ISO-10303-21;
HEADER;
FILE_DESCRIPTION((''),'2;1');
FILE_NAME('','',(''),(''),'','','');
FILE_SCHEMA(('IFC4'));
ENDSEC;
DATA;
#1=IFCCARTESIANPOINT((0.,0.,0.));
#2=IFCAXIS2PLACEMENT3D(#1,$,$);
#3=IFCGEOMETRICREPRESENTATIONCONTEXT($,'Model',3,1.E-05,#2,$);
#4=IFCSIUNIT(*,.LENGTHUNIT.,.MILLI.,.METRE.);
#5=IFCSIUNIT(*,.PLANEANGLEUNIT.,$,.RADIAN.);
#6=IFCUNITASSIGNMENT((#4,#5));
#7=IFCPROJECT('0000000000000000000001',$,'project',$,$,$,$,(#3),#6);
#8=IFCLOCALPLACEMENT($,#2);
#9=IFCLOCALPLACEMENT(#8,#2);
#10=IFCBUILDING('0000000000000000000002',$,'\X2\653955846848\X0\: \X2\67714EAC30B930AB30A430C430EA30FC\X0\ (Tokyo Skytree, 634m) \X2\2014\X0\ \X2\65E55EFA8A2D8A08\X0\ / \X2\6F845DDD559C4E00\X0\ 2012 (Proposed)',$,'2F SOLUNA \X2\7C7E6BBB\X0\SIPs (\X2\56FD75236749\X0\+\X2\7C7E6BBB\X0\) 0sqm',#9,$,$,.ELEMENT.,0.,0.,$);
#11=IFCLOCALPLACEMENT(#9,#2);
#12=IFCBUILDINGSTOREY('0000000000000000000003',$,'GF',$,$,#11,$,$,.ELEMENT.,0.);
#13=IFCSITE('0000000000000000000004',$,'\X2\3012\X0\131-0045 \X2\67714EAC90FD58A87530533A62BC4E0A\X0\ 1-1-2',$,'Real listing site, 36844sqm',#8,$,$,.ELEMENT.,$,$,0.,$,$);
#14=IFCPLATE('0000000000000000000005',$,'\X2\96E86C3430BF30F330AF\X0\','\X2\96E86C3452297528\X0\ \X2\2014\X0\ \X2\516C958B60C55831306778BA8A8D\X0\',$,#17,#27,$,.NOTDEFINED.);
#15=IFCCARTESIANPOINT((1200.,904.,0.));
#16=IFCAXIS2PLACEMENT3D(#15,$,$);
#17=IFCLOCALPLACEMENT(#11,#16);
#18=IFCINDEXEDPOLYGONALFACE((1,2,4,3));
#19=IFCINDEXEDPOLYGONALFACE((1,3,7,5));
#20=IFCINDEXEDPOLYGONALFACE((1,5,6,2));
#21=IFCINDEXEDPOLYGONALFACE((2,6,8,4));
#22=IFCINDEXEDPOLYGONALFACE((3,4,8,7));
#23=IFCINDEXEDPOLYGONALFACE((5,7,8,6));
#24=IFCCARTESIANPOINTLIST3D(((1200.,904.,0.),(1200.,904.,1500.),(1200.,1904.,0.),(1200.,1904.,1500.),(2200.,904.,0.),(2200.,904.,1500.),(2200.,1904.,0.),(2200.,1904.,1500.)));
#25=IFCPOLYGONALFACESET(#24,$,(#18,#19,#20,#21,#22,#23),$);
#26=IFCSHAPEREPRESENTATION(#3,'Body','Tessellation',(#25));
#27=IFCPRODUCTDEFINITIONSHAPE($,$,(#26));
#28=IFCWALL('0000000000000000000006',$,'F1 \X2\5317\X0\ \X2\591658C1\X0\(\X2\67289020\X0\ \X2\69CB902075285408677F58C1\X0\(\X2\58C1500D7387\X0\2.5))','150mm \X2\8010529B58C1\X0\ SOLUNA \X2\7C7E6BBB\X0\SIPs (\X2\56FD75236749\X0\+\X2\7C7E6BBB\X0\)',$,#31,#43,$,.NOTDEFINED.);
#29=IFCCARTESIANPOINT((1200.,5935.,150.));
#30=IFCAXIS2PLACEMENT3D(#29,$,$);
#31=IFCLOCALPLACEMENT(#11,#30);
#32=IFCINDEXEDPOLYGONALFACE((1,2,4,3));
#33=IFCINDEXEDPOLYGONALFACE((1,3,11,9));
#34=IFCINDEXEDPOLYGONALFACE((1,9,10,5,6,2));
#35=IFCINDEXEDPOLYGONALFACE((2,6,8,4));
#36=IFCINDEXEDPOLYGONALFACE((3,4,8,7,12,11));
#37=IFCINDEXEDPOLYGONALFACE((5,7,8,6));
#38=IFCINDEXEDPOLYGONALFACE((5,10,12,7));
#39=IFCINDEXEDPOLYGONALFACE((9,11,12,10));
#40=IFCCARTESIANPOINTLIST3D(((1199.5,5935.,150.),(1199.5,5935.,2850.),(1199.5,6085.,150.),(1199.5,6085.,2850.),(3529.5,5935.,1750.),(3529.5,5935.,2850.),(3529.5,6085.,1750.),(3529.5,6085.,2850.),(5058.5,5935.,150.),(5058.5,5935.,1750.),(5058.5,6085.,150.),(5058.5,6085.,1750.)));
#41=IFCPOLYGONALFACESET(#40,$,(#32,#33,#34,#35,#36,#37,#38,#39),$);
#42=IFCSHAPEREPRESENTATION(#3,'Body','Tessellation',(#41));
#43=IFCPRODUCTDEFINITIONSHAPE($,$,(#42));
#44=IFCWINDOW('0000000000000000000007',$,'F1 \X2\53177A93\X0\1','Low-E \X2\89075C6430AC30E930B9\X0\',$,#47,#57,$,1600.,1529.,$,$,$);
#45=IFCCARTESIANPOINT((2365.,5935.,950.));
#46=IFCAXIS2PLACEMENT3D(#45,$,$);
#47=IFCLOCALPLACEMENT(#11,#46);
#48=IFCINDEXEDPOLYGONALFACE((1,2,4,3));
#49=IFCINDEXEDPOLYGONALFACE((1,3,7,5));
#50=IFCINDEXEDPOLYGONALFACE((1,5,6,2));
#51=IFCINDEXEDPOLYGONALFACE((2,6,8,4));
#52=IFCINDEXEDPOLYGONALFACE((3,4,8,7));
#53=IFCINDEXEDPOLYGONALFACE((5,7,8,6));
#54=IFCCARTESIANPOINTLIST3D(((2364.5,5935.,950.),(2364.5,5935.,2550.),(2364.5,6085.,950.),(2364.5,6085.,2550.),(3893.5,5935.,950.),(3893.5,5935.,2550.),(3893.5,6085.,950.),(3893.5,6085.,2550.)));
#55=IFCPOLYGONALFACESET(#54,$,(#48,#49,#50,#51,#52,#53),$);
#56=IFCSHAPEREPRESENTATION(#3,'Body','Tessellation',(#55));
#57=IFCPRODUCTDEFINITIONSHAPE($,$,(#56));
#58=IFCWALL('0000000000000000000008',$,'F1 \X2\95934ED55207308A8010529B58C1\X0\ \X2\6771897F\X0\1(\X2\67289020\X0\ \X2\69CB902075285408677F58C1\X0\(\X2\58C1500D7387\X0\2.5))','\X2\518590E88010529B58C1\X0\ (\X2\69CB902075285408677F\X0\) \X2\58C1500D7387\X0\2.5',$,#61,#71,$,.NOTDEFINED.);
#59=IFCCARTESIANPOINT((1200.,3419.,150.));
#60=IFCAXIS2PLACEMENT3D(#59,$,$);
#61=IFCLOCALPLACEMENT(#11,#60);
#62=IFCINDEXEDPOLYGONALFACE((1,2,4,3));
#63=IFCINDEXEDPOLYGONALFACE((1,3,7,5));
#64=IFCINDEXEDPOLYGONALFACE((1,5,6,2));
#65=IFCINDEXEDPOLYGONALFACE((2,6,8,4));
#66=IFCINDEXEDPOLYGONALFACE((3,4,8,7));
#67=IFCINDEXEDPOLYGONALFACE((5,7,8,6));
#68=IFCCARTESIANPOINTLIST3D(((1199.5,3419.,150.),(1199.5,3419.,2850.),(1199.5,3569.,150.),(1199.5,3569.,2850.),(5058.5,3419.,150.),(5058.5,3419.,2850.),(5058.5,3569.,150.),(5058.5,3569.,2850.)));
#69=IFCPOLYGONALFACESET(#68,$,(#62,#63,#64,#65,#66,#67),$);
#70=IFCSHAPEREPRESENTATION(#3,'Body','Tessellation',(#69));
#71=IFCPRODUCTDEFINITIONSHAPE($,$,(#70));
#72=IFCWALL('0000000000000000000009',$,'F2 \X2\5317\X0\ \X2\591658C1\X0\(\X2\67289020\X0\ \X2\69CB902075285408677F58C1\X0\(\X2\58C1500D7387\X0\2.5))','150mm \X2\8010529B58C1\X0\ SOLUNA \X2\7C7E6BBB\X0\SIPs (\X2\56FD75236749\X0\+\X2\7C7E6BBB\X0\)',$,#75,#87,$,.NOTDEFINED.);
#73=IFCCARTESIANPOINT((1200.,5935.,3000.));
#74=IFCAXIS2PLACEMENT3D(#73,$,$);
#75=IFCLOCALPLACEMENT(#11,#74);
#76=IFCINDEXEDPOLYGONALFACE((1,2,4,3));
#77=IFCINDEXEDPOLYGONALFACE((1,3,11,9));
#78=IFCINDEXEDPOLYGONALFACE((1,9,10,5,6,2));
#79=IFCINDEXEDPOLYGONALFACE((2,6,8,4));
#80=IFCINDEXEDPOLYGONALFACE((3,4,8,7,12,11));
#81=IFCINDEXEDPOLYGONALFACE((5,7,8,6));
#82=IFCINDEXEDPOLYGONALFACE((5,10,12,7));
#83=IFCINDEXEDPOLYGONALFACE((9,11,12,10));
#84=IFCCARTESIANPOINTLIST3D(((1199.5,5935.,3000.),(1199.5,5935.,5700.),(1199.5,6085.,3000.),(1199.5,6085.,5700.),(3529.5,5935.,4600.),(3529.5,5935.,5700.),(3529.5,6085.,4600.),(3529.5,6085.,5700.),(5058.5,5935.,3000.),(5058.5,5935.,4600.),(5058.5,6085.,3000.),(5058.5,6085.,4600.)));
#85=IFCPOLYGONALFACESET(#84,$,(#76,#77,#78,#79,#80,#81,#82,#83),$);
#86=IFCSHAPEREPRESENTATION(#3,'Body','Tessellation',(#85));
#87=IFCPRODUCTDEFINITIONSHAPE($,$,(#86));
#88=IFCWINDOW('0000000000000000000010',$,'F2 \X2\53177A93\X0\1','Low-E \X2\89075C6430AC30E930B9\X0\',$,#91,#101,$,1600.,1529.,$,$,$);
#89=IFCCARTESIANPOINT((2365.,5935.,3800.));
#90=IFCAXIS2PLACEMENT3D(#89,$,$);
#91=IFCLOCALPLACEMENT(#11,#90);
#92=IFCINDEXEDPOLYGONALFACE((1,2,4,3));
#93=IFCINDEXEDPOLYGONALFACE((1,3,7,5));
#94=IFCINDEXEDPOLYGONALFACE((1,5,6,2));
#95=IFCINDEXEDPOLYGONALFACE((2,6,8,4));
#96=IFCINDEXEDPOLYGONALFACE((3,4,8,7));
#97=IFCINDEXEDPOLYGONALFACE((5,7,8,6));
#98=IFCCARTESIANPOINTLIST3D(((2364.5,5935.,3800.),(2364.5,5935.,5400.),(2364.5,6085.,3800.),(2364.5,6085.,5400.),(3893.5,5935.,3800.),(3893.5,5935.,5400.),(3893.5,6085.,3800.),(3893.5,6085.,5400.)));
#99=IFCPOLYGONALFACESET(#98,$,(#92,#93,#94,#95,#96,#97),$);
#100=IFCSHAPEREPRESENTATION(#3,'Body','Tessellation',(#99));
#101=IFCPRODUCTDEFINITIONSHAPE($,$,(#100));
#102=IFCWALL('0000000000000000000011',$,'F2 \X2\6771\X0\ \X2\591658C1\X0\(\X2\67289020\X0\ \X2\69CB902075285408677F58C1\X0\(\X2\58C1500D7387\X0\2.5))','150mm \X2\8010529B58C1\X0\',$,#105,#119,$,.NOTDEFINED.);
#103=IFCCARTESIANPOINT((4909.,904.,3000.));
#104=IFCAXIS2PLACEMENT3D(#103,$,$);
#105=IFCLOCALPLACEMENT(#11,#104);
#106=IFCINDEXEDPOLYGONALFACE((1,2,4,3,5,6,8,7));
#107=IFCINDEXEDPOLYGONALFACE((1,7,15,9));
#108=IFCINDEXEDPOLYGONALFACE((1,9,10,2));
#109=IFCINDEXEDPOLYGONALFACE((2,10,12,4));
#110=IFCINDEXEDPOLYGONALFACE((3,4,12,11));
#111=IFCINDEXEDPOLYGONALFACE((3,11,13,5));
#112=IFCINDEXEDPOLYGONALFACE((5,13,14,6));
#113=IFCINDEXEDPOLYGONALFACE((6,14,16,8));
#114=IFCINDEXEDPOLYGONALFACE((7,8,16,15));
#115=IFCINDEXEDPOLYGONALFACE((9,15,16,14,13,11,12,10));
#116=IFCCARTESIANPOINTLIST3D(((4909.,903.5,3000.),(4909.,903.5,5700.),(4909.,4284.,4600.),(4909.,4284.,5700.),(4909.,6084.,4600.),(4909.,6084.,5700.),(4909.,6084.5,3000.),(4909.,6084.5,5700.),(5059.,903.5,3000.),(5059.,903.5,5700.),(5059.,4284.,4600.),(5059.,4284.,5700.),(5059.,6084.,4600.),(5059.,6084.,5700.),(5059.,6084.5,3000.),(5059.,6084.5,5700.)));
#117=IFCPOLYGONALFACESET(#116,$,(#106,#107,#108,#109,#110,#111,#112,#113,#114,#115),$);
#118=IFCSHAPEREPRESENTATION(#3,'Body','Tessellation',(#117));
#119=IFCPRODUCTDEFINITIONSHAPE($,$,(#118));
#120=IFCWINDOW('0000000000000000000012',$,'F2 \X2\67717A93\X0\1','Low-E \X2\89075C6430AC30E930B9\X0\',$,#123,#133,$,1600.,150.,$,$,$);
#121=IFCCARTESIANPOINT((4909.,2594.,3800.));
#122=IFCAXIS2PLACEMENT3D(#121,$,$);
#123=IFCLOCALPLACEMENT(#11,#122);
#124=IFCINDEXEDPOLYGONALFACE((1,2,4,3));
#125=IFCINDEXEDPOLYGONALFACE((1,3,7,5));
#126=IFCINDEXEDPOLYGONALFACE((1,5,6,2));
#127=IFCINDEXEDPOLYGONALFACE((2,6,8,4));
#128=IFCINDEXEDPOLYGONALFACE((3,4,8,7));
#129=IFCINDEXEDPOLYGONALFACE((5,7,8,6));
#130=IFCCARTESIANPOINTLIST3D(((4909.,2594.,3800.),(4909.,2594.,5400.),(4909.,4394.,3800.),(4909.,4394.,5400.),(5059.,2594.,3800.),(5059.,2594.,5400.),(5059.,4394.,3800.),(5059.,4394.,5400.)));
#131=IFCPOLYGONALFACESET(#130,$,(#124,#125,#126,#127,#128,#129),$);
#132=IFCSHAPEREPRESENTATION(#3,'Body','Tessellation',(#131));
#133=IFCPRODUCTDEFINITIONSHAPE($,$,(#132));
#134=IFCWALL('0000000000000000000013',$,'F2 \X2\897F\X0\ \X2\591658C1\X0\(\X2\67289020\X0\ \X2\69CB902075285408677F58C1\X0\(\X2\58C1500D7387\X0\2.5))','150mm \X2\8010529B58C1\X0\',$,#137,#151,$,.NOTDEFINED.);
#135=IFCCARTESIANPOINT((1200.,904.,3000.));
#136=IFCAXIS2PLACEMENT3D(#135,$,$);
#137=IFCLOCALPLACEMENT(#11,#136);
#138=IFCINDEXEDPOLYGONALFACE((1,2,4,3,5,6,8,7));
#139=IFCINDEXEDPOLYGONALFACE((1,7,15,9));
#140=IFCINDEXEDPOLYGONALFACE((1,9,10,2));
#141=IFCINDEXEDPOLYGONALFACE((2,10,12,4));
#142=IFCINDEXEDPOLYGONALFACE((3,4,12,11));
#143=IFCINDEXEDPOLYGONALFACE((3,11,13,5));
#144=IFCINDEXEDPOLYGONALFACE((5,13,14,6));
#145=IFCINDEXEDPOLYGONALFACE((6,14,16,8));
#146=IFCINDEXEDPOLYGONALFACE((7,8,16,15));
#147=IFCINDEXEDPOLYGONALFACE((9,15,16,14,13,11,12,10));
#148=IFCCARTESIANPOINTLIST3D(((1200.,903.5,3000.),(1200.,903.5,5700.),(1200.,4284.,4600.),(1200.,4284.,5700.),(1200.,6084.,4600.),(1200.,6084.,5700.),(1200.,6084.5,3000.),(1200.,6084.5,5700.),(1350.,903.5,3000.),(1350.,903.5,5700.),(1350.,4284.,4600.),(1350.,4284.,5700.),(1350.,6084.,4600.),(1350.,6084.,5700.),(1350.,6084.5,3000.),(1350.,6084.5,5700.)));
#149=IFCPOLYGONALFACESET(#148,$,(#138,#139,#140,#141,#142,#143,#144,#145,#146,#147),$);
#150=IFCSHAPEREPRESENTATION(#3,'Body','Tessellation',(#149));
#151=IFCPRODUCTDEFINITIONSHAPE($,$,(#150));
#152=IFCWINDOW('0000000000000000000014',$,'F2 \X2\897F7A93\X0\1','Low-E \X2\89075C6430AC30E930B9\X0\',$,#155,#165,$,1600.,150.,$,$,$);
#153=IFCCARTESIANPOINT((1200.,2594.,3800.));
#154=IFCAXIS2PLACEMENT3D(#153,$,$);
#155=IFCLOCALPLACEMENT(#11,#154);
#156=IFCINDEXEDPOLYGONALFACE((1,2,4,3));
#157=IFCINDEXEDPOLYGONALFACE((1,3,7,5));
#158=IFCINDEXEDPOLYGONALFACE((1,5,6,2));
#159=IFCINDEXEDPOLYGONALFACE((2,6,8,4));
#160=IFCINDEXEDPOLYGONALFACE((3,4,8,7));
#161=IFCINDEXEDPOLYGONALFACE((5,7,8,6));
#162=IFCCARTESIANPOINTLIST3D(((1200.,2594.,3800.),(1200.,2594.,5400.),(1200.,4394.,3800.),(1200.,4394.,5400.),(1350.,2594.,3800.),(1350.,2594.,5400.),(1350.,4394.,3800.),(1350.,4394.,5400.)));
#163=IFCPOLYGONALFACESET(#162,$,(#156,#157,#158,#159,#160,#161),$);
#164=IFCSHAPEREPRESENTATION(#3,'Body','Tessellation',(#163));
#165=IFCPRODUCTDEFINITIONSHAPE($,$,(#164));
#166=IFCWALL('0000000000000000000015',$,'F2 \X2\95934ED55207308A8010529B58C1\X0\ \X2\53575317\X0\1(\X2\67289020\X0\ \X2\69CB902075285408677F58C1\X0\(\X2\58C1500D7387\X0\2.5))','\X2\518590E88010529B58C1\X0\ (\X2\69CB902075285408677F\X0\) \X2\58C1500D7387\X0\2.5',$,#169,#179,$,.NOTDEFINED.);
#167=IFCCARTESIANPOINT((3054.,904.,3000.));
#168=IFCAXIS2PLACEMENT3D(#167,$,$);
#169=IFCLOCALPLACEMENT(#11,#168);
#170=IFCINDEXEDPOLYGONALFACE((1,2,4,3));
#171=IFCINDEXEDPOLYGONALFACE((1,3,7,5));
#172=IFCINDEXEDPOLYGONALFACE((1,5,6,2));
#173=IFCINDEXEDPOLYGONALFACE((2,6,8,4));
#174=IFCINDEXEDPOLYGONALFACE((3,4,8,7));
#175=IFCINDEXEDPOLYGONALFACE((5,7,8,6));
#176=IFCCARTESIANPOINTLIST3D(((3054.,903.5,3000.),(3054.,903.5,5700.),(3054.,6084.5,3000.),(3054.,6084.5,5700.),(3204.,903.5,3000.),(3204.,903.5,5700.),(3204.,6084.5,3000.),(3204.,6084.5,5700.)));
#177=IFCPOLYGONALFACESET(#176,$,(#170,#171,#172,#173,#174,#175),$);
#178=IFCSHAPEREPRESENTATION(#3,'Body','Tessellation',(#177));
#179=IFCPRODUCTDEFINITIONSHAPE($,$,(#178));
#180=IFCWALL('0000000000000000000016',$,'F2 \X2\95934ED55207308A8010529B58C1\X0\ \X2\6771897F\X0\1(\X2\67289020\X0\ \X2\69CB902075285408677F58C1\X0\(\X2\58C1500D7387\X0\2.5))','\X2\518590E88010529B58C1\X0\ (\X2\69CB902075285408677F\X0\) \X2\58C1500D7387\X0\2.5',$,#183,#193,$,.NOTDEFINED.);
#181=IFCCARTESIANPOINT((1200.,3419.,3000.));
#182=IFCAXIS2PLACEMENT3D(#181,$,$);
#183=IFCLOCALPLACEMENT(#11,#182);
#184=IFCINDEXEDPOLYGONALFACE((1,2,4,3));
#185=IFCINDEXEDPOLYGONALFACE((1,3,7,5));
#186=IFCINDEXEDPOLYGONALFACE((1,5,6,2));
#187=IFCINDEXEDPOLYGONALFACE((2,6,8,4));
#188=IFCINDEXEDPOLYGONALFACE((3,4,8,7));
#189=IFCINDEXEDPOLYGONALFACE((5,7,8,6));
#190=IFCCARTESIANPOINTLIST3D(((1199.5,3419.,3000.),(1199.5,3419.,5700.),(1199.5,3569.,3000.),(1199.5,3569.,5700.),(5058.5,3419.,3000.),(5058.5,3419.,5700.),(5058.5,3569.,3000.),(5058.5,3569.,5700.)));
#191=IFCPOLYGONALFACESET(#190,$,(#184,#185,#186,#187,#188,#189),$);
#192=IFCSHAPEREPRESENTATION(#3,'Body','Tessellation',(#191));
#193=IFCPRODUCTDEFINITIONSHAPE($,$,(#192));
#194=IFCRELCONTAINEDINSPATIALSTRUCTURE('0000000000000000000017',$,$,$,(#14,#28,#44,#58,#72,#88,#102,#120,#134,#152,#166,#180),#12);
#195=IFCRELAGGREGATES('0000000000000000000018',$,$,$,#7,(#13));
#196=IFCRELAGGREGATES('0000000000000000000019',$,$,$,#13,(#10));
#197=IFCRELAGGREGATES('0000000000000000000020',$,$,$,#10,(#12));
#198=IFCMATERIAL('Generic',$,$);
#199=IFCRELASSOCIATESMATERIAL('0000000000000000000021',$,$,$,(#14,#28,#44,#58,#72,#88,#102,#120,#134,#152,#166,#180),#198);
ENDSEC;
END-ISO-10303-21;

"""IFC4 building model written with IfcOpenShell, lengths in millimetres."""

from ifc_helpers import new_model, si_unit, frame, frame_2d, origin, place, context, project, spatial, rectangle, extrude, material, element, fill, save


model = new_model("IFC4")

# Units and contexts
model_context = context("Model", 3, precision=1e-05, world=origin())
ifc_project = project(units=[si_unit("LENGTHUNIT", "METRE", prefix="MILLI"), si_unit("PLANEANGLEUNIT", "RADIAN")], contexts=[model_context])

# Site, building, storey
site_placement = place(None, origin())
site = spatial("IfcSite", under=ifc_project, at=site_placement, Name="〒131-0045 東京都墨田区押上 1-1-2", ObjectType="Real listing site, 36844sqm", CompositionType="ELEMENT", RefElevation=0.0)
building_placement = place(site_placement, origin())
building = spatial("IfcBuilding", under=site, at=building_placement, Name="改善案: 東京スカイツリー (Tokyo Skytree, 634m) — 日建設計 / 澄川喜一 2012 (Proposed)", ObjectType="2F SOLUNA 籾殻SIPs (国産杉+籾殻) 0sqm", CompositionType="ELEMENT", ElevationOfRefHeight=0.0, ElevationOfTerrain=0.0)
storey_placement = place(building_placement, origin())
storey = spatial("IfcBuildingStorey", under=building, at=storey_placement, Name="GF", CompositionType="ELEMENT", Elevation=0.0)

# Plate
ifc_material_1 = material(Name="Generic")
plate_placement = place(storey_placement, frame((1200.0, 904.0, 0.0)))
element("IfcPlate", 1, at=plate_placement, inside=storey, material=ifc_material_1, Name="雨水タンク", Description="雨水利用 — 公開情報で確認", PredefinedType="NOTDEFINED", context=model_context, shape_type="SweptSolid", body=[
    extrude(rectangle(XDim=1000.0, YDim=1000.0, at=frame_2d((500.0, 500.0))), frame((1200.0, 904.0, 0.0)), (0.0, 0.0, 1.0), 1500.0),
])

# Wall, opening, window
wall_1_placement = place(storey_placement, frame((1200.0, 5935.0, 150.0)))
wall_1 = element("IfcWall", 2, at=wall_1_placement, inside=storey, material=ifc_material_1, Name="F1 北 外壁(木造 構造用合板壁(壁倍率2.5))", Description="150mm 耐力壁 SOLUNA 籾殻SIPs (国産杉+籾殻)", PredefinedType="NOTDEFINED", context=model_context, shape_type="SweptSolid", body=[
    extrude(rectangle(XDim=3859.0, YDim=150.0, at=frame_2d((1929.0, 75.0))), frame((1200.0, 5935.0, 150.0)), (0.0, 0.0, 1.0), 2700.0),
])
opening_1_placement = place(storey_placement, frame((2365.0, 5935.0, 950.0)))
opening_1 = element("IfcOpeningElement", 3, at=opening_1_placement, cuts=wall_1, PredefinedType="NOTDEFINED", context=model_context, shape_type="SweptSolid", body=[
    extrude(rectangle(XDim=1529.0, YDim=150.0, at=frame_2d((764.0, 75.0))), frame((2365.0, 5935.0, 950.0)), (0.0, 0.0, 1.0), 1600.0),
])
window_1_placement = place(storey_placement, frame((2365.0, 5935.0, 950.0)))
window_1 = element("IfcWindow", 4, at=window_1_placement, inside=storey, material=ifc_material_1, Name="F1 北窓1", Description="Low-E 複層ガラス", OverallHeight=1600.0, OverallWidth=1529.0, context=model_context, shape_type="SweptSolid", body=[
    extrude(rectangle(XDim=1529.0, YDim=150.0, at=frame_2d((764.0, 75.0))), frame((2365.0, 5935.0, 950.0)), (0.0, 0.0, 1.0), 1600.0),
])
fill(opening_1, window_1)

# Wall
wall_2_placement = place(storey_placement, frame((1200.0, 3419.0, 150.0)))
element("IfcWall", 5, at=wall_2_placement, inside=storey, material=ifc_material_1, Name="F1 間仕切り耐力壁 東西1(木造 構造用合板壁(壁倍率2.5))", Description="内部耐力壁 (構造用合板) 壁倍率2.5", PredefinedType="NOTDEFINED", context=model_context, shape_type="SweptSolid", body=[
    extrude(rectangle(XDim=3859.0, YDim=150.0, at=frame_2d((1929.0, 75.0))), frame((1200.0, 3419.0, 150.0)), (0.0, 0.0, 1.0), 2700.0),
])

# Walls, openings, windows
wall_3_placement = place(storey_placement, frame((1200.0, 5935.0, 3000.0)))
wall_3 = element("IfcWall", 6, at=wall_3_placement, inside=storey, material=ifc_material_1, Name="F2 北 外壁(木造 構造用合板壁(壁倍率2.5))", Description="150mm 耐力壁 SOLUNA 籾殻SIPs (国産杉+籾殻)", PredefinedType="NOTDEFINED", context=model_context, shape_type="SweptSolid", body=[
    extrude(rectangle(XDim=3859.0, YDim=150.0, at=frame_2d((1929.0, 75.0))), frame((1200.0, 5935.0, 3000.0)), (0.0, 0.0, 1.0), 2700.0),
])
opening_2_placement = place(storey_placement, frame((2365.0, 5935.0, 3800.0)))
opening_2 = element("IfcOpeningElement", 7, at=opening_2_placement, cuts=wall_3, PredefinedType="NOTDEFINED", context=model_context, shape_type="SweptSolid", body=[
    extrude(rectangle(XDim=1529.0, YDim=150.0, at=frame_2d((764.0, 75.0))), frame((2365.0, 5935.0, 3800.0)), (0.0, 0.0, 1.0), 1600.0),
])
window_2_placement = place(storey_placement, frame((2365.0, 5935.0, 3800.0)))
window_2 = element("IfcWindow", 8, at=window_2_placement, inside=storey, material=ifc_material_1, Name="F2 北窓1", Description="Low-E 複層ガラス", OverallHeight=1600.0, OverallWidth=1529.0, context=model_context, shape_type="SweptSolid", body=[
    extrude(rectangle(XDim=1529.0, YDim=150.0, at=frame_2d((764.0, 75.0))), frame((2365.0, 5935.0, 3800.0)), (0.0, 0.0, 1.0), 1600.0),
])
fill(opening_2, window_2)
wall_4_placement = place(storey_placement, frame((4909.0, 904.0, 3000.0)))
wall_4 = element("IfcWall", 9, at=wall_4_placement, inside=storey, material=ifc_material_1, Name="F2 東 外壁(木造 構造用合板壁(壁倍率2.5))", Description="150mm 耐力壁", PredefinedType="NOTDEFINED", context=model_context, shape_type="SweptSolid", body=[
    extrude(rectangle(XDim=150.0, YDim=5181.0, at=frame_2d((75.0, 2590.0))), frame((4909.0, 904.0, 3000.0)), (0.0, 0.0, 1.0), 2700.0),
])
opening_3_placement = place(storey_placement, frame((4909.0, 2594.0, 3800.0)))
opening_3 = element("IfcOpeningElement", 10, at=opening_3_placement, cuts=wall_4, PredefinedType="NOTDEFINED", context=model_context, shape_type="SweptSolid", body=[
    extrude(rectangle(XDim=150.0, YDim=1800.0, at=frame_2d((75.0, 900.0))), frame((4909.0, 2594.0, 3800.0)), (0.0, 0.0, 1.0), 1600.0),
])
window_3_placement = place(storey_placement, frame((4909.0, 2594.0, 3800.0)))
window_3 = element("IfcWindow", 11, at=window_3_placement, inside=storey, material=ifc_material_1, Name="F2 東窓1", Description="Low-E 複層ガラス", OverallHeight=1600.0, OverallWidth=150.0, context=model_context, shape_type="SweptSolid", body=[
    extrude(rectangle(XDim=150.0, YDim=1800.0, at=frame_2d((75.0, 900.0))), frame((4909.0, 2594.0, 3800.0)), (0.0, 0.0, 1.0), 1600.0),
])
fill(opening_3, window_3)
wall_5_placement = place(storey_placement, frame((1200.0, 904.0, 3000.0)))
wall_5 = element("IfcWall", 12, at=wall_5_placement, inside=storey, material=ifc_material_1, Name="F2 西 外壁(木造 構造用合板壁(壁倍率2.5))", Description="150mm 耐力壁", PredefinedType="NOTDEFINED", context=model_context, shape_type="SweptSolid", body=[
    extrude(rectangle(XDim=150.0, YDim=5181.0, at=frame_2d((75.0, 2590.0))), frame((1200.0, 904.0, 3000.0)), (0.0, 0.0, 1.0), 2700.0),
])
opening_4_placement = place(storey_placement, frame((1200.0, 2594.0, 3800.0)))
opening_4 = element("IfcOpeningElement", 13, at=opening_4_placement, cuts=wall_5, PredefinedType="NOTDEFINED", context=model_context, shape_type="SweptSolid", body=[
    extrude(rectangle(XDim=150.0, YDim=1800.0, at=frame_2d((75.0, 900.0))), frame((1200.0, 2594.0, 3800.0)), (0.0, 0.0, 1.0), 1600.0),
])
window_4_placement = place(storey_placement, frame((1200.0, 2594.0, 3800.0)))
window_4 = element("IfcWindow", 14, at=window_4_placement, inside=storey, material=ifc_material_1, Name="F2 西窓1", Description="Low-E 複層ガラス", OverallHeight=1600.0, OverallWidth=150.0, context=model_context, shape_type="SweptSolid", body=[
    extrude(rectangle(XDim=150.0, YDim=1800.0, at=frame_2d((75.0, 900.0))), frame((1200.0, 2594.0, 3800.0)), (0.0, 0.0, 1.0), 1600.0),
])
fill(opening_4, window_4)

# Walls
wall_6_placement = place(storey_placement, frame((3054.0, 904.0, 3000.0)))
element("IfcWall", 15, at=wall_6_placement, inside=storey, material=ifc_material_1, Name="F2 間仕切り耐力壁 南北1(木造 構造用合板壁(壁倍率2.5))", Description="内部耐力壁 (構造用合板) 壁倍率2.5", PredefinedType="NOTDEFINED", context=model_context, shape_type="SweptSolid", body=[
    extrude(rectangle(XDim=150.0, YDim=5181.0, at=frame_2d((75.0, 2590.0))), frame((3054.0, 904.0, 3000.0)), (0.0, 0.0, 1.0), 2700.0),
])
wall_7_placement = place(storey_placement, frame((1200.0, 3419.0, 3000.0)))
element("IfcWall", 16, at=wall_7_placement, inside=storey, material=ifc_material_1, Name="F2 間仕切り耐力壁 東西1(木造 構造用合板壁(壁倍率2.5))", Description="内部耐力壁 (構造用合板) 壁倍率2.5", PredefinedType="NOTDEFINED", context=model_context, shape_type="SweptSolid", body=[
    extrude(rectangle(XDim=3859.0, YDim=150.0, at=frame_2d((1929.0, 75.0))), frame((1200.0, 3419.0, 3000.0)), (0.0, 0.0, 1.0), 2700.0),
])

save(model, "model.ifc")
